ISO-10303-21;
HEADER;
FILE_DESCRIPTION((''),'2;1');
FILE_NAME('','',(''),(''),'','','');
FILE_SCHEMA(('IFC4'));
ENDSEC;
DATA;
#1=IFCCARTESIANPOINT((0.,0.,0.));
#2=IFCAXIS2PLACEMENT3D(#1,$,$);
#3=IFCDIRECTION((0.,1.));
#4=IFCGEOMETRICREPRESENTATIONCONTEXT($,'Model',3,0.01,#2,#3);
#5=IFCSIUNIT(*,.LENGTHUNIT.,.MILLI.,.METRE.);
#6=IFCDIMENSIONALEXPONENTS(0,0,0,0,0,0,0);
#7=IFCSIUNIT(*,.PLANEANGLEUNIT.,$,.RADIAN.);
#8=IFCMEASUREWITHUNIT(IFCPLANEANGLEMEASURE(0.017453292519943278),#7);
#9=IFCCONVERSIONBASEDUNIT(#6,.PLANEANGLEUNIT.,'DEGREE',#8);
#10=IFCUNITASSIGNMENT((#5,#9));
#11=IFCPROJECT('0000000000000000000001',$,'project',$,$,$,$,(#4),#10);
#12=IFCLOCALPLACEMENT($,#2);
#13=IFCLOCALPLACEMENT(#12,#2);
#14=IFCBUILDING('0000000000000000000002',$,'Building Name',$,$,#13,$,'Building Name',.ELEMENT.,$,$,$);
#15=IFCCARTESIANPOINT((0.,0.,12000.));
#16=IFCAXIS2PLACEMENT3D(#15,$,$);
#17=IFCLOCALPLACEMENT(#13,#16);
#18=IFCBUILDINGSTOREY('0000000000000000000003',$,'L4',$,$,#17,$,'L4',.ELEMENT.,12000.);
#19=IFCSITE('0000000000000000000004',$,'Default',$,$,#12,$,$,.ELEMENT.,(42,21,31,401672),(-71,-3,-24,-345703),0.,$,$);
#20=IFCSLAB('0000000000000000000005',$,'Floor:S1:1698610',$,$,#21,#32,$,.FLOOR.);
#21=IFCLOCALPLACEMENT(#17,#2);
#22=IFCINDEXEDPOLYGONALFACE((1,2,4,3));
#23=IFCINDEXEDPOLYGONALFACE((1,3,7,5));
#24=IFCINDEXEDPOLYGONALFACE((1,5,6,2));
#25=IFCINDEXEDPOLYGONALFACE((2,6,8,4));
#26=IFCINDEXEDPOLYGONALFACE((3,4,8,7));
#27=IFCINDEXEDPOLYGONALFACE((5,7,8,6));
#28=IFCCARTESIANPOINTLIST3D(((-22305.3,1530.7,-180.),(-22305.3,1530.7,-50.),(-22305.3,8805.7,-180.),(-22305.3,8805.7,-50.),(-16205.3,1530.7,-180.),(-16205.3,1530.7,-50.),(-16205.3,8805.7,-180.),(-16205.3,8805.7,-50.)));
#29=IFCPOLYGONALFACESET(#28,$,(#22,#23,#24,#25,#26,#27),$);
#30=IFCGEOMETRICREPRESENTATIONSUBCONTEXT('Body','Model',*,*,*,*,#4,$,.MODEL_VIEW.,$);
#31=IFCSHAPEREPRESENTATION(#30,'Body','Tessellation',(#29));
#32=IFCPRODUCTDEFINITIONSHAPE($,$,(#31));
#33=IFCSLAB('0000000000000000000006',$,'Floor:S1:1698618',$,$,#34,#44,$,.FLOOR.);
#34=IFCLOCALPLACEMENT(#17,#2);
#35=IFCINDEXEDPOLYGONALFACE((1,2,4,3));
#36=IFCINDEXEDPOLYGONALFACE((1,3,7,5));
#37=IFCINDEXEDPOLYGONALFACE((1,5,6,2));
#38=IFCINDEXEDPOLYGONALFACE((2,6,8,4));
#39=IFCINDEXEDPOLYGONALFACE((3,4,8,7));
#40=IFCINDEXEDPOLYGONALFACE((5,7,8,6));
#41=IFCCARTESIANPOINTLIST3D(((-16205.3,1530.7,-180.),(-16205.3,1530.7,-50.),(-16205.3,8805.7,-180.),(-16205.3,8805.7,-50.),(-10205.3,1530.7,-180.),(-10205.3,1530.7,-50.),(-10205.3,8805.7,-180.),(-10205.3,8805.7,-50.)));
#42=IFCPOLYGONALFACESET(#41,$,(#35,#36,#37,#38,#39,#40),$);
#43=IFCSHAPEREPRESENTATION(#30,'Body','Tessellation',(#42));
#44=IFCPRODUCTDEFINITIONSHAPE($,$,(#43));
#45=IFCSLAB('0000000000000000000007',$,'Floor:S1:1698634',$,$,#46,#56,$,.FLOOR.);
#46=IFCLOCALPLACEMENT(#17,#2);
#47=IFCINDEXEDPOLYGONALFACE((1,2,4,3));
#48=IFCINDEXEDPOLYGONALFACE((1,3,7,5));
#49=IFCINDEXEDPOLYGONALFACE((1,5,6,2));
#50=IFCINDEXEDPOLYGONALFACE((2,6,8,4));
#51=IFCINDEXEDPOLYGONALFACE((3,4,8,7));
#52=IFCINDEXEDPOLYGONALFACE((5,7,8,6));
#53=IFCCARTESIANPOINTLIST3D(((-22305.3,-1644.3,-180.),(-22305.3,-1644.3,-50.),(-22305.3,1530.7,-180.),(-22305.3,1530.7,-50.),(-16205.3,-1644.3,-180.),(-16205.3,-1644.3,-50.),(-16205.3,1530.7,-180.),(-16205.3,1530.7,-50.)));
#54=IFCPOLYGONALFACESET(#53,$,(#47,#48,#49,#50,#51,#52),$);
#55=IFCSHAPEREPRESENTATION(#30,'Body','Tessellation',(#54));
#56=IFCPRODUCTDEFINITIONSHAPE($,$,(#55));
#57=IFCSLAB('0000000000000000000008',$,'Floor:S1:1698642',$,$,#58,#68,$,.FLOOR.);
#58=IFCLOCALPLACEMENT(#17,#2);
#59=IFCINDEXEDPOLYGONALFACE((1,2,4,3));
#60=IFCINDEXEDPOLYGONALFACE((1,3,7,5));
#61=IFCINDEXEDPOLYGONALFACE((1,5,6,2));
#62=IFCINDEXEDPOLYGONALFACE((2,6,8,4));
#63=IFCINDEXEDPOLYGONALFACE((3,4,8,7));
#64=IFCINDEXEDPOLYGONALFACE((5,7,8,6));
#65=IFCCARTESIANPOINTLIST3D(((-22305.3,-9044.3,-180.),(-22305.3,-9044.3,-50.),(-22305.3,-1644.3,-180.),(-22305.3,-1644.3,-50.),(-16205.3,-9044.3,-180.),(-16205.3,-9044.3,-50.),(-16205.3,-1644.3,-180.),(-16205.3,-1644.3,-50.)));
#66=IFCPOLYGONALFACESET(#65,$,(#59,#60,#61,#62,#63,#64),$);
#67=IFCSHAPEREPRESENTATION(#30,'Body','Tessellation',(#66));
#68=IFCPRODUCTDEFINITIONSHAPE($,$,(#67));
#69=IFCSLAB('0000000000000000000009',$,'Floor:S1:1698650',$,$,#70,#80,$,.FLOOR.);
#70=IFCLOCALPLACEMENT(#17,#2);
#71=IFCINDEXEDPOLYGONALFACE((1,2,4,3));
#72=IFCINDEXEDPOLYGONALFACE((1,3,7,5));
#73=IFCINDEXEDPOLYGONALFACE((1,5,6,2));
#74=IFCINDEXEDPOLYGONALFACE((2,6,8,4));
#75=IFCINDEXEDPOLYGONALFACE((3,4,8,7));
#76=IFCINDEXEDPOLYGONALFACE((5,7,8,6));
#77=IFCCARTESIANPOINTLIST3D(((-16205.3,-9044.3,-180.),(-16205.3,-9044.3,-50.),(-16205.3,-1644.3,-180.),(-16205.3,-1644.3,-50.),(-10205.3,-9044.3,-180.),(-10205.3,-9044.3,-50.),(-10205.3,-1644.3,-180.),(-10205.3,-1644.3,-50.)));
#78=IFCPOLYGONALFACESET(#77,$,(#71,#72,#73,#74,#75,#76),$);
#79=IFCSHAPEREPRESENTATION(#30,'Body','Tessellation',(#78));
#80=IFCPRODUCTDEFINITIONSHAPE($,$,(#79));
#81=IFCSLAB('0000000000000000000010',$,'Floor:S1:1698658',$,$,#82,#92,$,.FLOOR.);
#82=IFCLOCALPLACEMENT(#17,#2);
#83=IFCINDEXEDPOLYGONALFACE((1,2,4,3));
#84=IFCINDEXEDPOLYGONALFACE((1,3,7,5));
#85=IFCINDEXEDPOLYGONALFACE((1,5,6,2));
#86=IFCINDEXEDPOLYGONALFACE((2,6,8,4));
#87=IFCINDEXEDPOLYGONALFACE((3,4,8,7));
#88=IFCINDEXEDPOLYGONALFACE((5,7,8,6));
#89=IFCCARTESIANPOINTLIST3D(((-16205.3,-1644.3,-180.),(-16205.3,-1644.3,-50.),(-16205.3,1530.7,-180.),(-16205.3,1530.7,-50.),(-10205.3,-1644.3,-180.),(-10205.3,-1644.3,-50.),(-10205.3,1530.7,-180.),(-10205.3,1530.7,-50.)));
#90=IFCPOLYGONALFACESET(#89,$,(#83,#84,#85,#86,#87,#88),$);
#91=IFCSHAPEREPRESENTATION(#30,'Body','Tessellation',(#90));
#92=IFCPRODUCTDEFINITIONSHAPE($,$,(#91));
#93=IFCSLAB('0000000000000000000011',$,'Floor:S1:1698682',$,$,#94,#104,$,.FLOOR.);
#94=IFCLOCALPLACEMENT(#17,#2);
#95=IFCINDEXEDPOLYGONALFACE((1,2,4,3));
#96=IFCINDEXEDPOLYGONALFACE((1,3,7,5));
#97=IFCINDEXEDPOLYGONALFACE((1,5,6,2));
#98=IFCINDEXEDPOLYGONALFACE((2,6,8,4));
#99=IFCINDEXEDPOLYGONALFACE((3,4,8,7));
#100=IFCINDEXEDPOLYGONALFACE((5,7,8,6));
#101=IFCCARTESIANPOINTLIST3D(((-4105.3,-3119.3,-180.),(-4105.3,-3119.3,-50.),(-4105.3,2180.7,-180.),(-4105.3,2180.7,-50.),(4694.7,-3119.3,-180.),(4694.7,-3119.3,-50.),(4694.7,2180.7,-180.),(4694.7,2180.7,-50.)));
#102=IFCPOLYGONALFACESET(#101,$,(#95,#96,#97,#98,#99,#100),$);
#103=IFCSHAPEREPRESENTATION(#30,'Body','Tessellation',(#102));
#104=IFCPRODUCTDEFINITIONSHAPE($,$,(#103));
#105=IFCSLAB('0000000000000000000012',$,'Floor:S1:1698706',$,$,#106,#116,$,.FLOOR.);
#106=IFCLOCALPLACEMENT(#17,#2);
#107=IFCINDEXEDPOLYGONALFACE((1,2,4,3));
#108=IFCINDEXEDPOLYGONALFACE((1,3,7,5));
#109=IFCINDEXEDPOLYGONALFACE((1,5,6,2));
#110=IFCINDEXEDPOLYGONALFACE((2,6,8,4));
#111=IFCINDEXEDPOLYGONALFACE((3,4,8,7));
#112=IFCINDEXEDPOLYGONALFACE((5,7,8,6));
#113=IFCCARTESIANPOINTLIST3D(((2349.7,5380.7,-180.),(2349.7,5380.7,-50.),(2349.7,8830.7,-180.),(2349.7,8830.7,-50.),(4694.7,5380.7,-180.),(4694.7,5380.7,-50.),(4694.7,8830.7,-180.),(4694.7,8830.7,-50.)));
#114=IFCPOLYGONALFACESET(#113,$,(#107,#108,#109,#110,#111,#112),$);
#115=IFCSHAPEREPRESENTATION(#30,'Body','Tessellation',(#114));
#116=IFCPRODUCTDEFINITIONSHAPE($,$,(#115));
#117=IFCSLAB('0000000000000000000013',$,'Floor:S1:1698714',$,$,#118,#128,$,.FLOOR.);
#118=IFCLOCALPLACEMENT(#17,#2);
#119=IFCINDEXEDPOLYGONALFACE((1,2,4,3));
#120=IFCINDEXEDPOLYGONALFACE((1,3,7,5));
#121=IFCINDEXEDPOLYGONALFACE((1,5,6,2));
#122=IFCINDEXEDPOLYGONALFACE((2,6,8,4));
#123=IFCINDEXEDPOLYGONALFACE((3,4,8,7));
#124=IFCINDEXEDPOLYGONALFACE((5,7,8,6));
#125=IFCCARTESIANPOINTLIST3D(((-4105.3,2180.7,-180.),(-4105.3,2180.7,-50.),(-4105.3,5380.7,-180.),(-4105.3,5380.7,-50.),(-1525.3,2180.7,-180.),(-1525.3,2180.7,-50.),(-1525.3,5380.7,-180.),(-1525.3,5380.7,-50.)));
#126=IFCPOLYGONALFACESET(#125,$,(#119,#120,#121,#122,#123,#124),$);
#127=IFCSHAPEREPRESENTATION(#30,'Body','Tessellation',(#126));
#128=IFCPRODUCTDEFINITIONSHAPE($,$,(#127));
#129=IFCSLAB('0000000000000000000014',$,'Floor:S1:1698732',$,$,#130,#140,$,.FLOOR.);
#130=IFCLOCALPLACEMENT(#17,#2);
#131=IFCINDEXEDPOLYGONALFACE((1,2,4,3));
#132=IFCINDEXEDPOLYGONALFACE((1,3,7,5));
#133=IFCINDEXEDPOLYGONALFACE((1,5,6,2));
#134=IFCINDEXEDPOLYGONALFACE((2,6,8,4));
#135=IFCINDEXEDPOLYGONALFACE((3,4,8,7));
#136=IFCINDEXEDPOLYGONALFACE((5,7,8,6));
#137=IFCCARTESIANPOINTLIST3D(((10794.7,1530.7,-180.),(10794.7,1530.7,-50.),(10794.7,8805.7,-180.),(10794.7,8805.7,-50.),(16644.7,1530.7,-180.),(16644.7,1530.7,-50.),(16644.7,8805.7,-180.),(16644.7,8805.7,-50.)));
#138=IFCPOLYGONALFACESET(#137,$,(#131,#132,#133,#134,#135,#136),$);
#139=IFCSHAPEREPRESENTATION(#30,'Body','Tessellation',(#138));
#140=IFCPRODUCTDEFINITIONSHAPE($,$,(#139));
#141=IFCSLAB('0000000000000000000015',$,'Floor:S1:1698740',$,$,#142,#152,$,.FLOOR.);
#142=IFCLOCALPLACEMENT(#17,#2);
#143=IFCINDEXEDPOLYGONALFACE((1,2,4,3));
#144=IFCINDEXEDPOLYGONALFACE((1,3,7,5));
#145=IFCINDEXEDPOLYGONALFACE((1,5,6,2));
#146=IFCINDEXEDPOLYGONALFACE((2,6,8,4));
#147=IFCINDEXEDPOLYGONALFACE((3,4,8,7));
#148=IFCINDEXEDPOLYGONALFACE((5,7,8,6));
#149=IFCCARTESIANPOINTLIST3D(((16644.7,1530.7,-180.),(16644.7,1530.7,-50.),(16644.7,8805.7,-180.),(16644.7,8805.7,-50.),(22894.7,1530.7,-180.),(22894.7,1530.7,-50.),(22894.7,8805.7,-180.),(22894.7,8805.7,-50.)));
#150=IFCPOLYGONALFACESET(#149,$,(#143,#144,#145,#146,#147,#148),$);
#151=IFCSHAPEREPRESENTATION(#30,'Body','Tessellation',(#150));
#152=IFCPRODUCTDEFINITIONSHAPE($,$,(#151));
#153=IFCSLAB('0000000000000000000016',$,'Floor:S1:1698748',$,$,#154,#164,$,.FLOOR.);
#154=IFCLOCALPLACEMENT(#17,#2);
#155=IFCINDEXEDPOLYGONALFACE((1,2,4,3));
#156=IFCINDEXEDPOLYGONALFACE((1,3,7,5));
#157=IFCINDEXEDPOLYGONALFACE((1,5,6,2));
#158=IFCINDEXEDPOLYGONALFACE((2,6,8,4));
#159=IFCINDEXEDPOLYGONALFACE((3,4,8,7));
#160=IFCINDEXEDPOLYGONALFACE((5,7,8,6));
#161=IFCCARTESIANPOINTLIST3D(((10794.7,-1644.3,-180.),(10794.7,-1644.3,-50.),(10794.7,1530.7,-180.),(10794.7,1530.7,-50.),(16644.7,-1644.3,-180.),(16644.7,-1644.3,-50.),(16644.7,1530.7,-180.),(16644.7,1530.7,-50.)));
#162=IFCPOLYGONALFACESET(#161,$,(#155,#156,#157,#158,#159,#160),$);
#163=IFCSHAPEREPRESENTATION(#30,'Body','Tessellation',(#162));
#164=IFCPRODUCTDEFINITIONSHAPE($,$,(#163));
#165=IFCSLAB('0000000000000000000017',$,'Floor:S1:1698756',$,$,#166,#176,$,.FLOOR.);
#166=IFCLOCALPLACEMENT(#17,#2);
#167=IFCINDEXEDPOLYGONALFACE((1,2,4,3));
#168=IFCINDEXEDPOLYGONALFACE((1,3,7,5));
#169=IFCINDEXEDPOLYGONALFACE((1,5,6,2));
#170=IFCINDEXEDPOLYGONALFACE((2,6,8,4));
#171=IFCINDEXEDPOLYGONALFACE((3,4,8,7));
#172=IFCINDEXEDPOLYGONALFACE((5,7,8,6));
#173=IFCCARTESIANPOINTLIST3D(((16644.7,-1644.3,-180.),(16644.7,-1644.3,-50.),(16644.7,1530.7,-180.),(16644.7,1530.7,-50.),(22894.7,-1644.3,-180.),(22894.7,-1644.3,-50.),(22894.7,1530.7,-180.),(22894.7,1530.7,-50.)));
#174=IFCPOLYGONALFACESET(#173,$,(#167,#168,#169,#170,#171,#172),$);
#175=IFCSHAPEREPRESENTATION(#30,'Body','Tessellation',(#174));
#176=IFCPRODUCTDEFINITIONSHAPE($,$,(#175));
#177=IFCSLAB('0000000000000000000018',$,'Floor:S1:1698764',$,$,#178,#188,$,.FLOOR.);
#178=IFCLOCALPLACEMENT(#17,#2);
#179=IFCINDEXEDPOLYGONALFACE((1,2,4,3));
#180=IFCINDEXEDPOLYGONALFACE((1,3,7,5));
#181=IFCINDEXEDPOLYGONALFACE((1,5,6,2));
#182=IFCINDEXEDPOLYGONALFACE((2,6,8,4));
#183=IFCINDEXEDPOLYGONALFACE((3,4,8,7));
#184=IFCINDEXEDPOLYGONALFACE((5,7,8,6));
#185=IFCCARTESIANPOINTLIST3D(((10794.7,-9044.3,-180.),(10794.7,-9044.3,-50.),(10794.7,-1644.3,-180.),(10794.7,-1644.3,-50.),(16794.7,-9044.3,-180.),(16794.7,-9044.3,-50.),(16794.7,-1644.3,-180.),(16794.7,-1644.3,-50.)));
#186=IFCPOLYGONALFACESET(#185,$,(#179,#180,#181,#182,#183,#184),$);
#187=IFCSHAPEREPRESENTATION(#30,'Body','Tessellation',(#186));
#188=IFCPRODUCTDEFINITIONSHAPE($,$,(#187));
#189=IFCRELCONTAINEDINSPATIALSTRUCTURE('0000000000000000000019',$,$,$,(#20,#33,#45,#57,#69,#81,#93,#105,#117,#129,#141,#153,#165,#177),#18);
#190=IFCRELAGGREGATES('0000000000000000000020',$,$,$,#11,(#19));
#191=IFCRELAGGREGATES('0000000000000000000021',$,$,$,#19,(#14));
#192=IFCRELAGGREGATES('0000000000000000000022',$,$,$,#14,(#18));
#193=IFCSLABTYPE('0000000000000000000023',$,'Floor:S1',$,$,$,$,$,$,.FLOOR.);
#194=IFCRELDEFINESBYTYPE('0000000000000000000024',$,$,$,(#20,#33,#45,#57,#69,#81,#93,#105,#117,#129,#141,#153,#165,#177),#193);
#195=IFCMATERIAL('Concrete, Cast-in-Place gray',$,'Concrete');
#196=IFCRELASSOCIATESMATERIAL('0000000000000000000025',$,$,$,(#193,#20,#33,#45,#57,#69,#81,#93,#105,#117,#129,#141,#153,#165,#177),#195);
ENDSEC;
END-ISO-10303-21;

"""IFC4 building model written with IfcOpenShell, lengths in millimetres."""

from ifc_helpers import new_model, entity, si_unit, converted_unit, direction, frame, origin, place, context, subcontext, project, spatial, indexed_curve, outline, extrude, material, type_object, element, save


model = new_model("IFC4")

# Units and contexts
model_context = context("Model", 3, precision=0.01, world=origin(), true_north=direction((0.0, 1.0)))
body_context = subcontext(model_context, "Body", "Model", "MODEL_VIEW")
ifc_project = project(units=[si_unit("LENGTHUNIT", "METRE", prefix="MILLI"), converted_unit("PLANEANGLEUNIT", "DEGREE", entity("IfcPlaneAngleMeasure", 0.017453292519943278), si_unit("PLANEANGLEUNIT", "RADIAN"), dimensions=[0, 0, 0, 0, 0, 0, 0])], contexts=[model_context])

# Site, building, storey
site_placement = place(None, origin())
site = spatial("IfcSite", under=ifc_project, at=site_placement, Name="Default", CompositionType="ELEMENT", RefLatitude=(42, 21, 31, 401672), RefLongitude=(-71, -3, -24, -345703), RefElevation=0.0)
building_placement = place(site_placement, origin())
building = spatial("IfcBuilding", under=site, at=building_placement, Name="Building Name", LongName="Building Name", CompositionType="ELEMENT")
storey_placement = place(building_placement, frame((0.0, 0.0, 12000.0)))
storey = spatial("IfcBuildingStorey", under=building, at=storey_placement, Name="L4", LongName="L4", CompositionType="ELEMENT", Elevation=12000.0)

# Shared definitions
ifc_material = material(Name="Concrete, Cast-in-Place gray", Category="Concrete")

# Slabs
slab_type = type_object("IfcSlabType", Name="Floor:S1", PredefinedType="FLOOR", material=ifc_material)
slab_1_placement = place(storey_placement, origin())
element("IfcSlab", 1, at=slab_1_placement, inside=storey, type_object=slab_type, material=ifc_material, Name="Floor:S1:1698610", PredefinedType="FLOOR", context=body_context, shape_type="SweptSolid", body=[
    extrude(outline(indexed_curve([(-3637.5, -3050.0), (3637.5, -3050.0), (3637.5, 3050.0), (-3637.5, 3050.0), (-3637.5, -3050.0)], self_intersect=False)), frame((-19255.3, 5168.2, -50.0), z_axis=(0.0, 0.0, -1.0), x_axis=(0.0, 1.0, 0.0)), (0.0, 0.0, 1.0), 130.0),
])
slab_2_placement = place(storey_placement, origin())
element("IfcSlab", 2, at=slab_2_placement, inside=storey, type_object=slab_type, material=ifc_material, Name="Floor:S1:1698618", PredefinedType="FLOOR", context=body_context, shape_type="SweptSolid", body=[
    extrude(outline(indexed_curve([(-3637.5, -3000.0), (3637.5, -3000.0), (3637.5, 3000.0), (-3637.5, 3000.0), (-3637.5, -3000.0)], self_intersect=False)), frame((-13205.3, 5168.2, -50.0), z_axis=(0.0, 0.0, -1.0), x_axis=(0.0, 1.0, 0.0)), (0.0, 0.0, 1.0), 130.0),
])
slab_3_placement = place(storey_placement, origin())
element("IfcSlab", 3, at=slab_3_placement, inside=storey, type_object=slab_type, material=ifc_material, Name="Floor:S1:1698634", PredefinedType="FLOOR", context=body_context, shape_type="SweptSolid", body=[
    extrude(outline(indexed_curve([(-1587.5, -3050.0), (1587.5, -3050.0), (1587.5, 3050.0), (-1587.5, 3050.0), (-1587.5, -3050.0)], self_intersect=False)), frame((-19255.3, -56.8, -50.0), z_axis=(0.0, 0.0, -1.0), x_axis=(0.0, 1.0, 0.0)), (0.0, 0.0, 1.0), 130.0),
])
slab_4_placement = place(storey_placement, origin())
element("IfcSlab", 4, at=slab_4_placement, inside=storey, type_object=slab_type, material=ifc_material, Name="Floor:S1:1698642", PredefinedType="FLOOR", context=body_context, shape_type="SweptSolid", body=[
    extrude(outline(indexed_curve([(-3700.0, -3050.0), (3700.0, -3050.0), (3700.0, 3050.0), (-3700.0, 3050.0), (-3700.0, -3050.0)], self_intersect=False)), frame((-19255.3, -5344.3, -50.0), z_axis=(0.0, 0.0, -1.0), x_axis=(0.0, 1.0, 0.0)), (0.0, 0.0, 1.0), 130.0),
])
slab_5_placement = place(storey_placement, origin())
element("IfcSlab", 5, at=slab_5_placement, inside=storey, type_object=slab_type, material=ifc_material, Name="Floor:S1:1698650", PredefinedType="FLOOR", context=body_context, shape_type="SweptSolid", body=[
    extrude(outline(indexed_curve([(-3700.0, -3000.0), (3700.0, -3000.0), (3700.0, 3000.0), (-3700.0, 3000.0), (-3700.0, -3000.0)], self_intersect=False)), frame((-13205.3, -5344.3, -50.0), z_axis=(0.0, 0.0, -1.0), x_axis=(0.0, 1.0, 0.0)), (0.0, 0.0, 1.0), 130.0),
])
slab_6_placement = place(storey_placement, origin())
element("IfcSlab", 6, at=slab_6_placement, inside=storey, type_object=slab_type, material=ifc_material, Name="Floor:S1:1698658", PredefinedType="FLOOR", context=body_context, shape_type="SweptSolid", body=[
    extrude(outline(indexed_curve([(-1587.5, -3000.0), (1587.5, -3000.0), (1587.5, 3000.0), (-1587.5, 3000.0), (-1587.5, -3000.0)], self_intersect=False)), frame((-13205.3, -56.8, -50.0), z_axis=(0.0, 0.0, -1.0), x_axis=(0.0, 1.0, 0.0)), (0.0, 0.0, 1.0), 130.0),
])
slab_7_placement = place(storey_placement, origin())
element("IfcSlab", 7, at=slab_7_placement, inside=storey, type_object=slab_type, material=ifc_material, Name="Floor:S1:1698682", PredefinedType="FLOOR", context=body_context, shape_type="SweptSolid", body=[
    extrude(outline(indexed_curve([(-2650.0, -4400.0), (2650.0, -4400.0), (2650.0, 4400.0), (-2650.0, 4400.0), (-2650.0, -4400.0)], self_intersect=False)), frame((294.7, -469.3, -50.0), z_axis=(0.0, 0.0, -1.0), x_axis=(0.0, 1.0, 0.0)), (0.0, 0.0, 1.0), 130.0),
])
slab_8_placement = place(storey_placement, origin())
element("IfcSlab", 8, at=slab_8_placement, inside=storey, type_object=slab_type, material=ifc_material, Name="Floor:S1:1698706", PredefinedType="FLOOR", context=body_context, shape_type="SweptSolid", body=[
    extrude(outline(indexed_curve([(-1725.0, -1172.5), (1725.0, -1172.5), (1725.0, 1172.5), (-1725.0, 1172.5), (-1725.0, -1172.5)], self_intersect=False)), frame((3522.2, 7105.7, -50.0), z_axis=(0.0, 0.0, -1.0), x_axis=(0.0, 1.0, 0.0)), (0.0, 0.0, 1.0), 130.0),
])
slab_9_placement = place(storey_placement, origin())
element("IfcSlab", 9, at=slab_9_placement, inside=storey, type_object=slab_type, material=ifc_material, Name="Floor:S1:1698714", PredefinedType="FLOOR", context=body_context, shape_type="SweptSolid", body=[
    extrude(outline(indexed_curve([(-1600.0, -1290.0), (1600.0, -1290.0), (1600.0, 1290.0), (-1600.0, 1290.0), (-1600.0, -1290.0)], self_intersect=False)), frame((-2815.3, 3780.7, -50.0), z_axis=(0.0, 0.0, -1.0), x_axis=(0.0, 1.0, 0.0)), (0.0, 0.0, 1.0), 130.0),
])
slab_10_placement = place(storey_placement, origin())
element("IfcSlab", 10, at=slab_10_placement, inside=storey, type_object=slab_type, material=ifc_material, Name="Floor:S1:1698732", PredefinedType="FLOOR", context=body_context, shape_type="SweptSolid", body=[
    extrude(outline(indexed_curve([(-3637.5, -2925.0), (3637.5, -2925.0), (3637.5, 2925.0), (-3637.5, 2925.0), (-3637.5, -2925.0)], self_intersect=False)), frame((13719.7, 5168.2, -50.0), z_axis=(0.0, 0.0, -1.0), x_axis=(0.0, 1.0, 0.0)), (0.0, 0.0, 1.0), 130.0),
])
slab_11_placement = place(storey_placement, origin())
element("IfcSlab", 11, at=slab_11_placement, inside=storey, type_object=slab_type, material=ifc_material, Name="Floor:S1:1698740", PredefinedType="FLOOR", context=body_context, shape_type="SweptSolid", body=[
    extrude(outline(indexed_curve([(-3637.5, -3125.0), (3637.5, -3125.0), (3637.5, 3125.0), (-3637.5, 3125.0), (-3637.5, -3125.0)], self_intersect=False)), frame((19769.7, 5168.2, -50.0), z_axis=(0.0, 0.0, -1.0), x_axis=(0.0, 1.0, 0.0)), (0.0, 0.0, 1.0), 130.0),
])
slab_12_placement = place(storey_placement, origin())
element("IfcSlab", 12, at=slab_12_placement, inside=storey, type_object=slab_type, material=ifc_material, Name="Floor:S1:1698748", PredefinedType="FLOOR", context=body_context, shape_type="SweptSolid", body=[
    extrude(outline(indexed_curve([(-1587.5, -2925.0), (1587.5, -2925.0), (1587.5, 2925.0), (-1587.5, 2925.0), (-1587.5, -2925.0)], self_intersect=False)), frame((13719.7, -56.8, -50.0), z_axis=(0.0, 0.0, -1.0), x_axis=(0.0, 1.0, 0.0)), (0.0, 0.0, 1.0), 130.0),
])
slab_13_placement = place(storey_placement, origin())
element("IfcSlab", 13, at=slab_13_placement, inside=storey, type_object=slab_type, material=ifc_material, Name="Floor:S1:1698756", PredefinedType="FLOOR", context=body_context, shape_type="SweptSolid", body=[
    extrude(outline(indexed_curve([(-1587.5, -3125.0), (1587.5, -3125.0), (1587.5, 3125.0), (-1587.5, 3125.0), (-1587.5, -3125.0)], self_intersect=False)), frame((19769.7, -56.8, -50.0), z_axis=(0.0, 0.0, -1.0), x_axis=(0.0, 1.0, 0.0)), (0.0, 0.0, 1.0), 130.0),
])
slab_14_placement = place(storey_placement, origin())
element("IfcSlab", 14, at=slab_14_placement, inside=storey, type_object=slab_type, material=ifc_material, Name="Floor:S1:1698764", PredefinedType="FLOOR", context=body_context, shape_type="SweptSolid", body=[
    extrude(outline(indexed_curve([(-3700.0, -3000.0), (3700.0, -3000.0), (3700.0, 3000.0), (-3700.0, 3000.0), (-3700.0, -3000.0)], self_intersect=False)), frame((13794.7, -5344.3, -50.0), z_axis=(0.0, 0.0, -1.0), x_axis=(0.0, 1.0, 0.0)), (0.0, 0.0, 1.0), 130.0),
])

save(model, "model.ifc")
